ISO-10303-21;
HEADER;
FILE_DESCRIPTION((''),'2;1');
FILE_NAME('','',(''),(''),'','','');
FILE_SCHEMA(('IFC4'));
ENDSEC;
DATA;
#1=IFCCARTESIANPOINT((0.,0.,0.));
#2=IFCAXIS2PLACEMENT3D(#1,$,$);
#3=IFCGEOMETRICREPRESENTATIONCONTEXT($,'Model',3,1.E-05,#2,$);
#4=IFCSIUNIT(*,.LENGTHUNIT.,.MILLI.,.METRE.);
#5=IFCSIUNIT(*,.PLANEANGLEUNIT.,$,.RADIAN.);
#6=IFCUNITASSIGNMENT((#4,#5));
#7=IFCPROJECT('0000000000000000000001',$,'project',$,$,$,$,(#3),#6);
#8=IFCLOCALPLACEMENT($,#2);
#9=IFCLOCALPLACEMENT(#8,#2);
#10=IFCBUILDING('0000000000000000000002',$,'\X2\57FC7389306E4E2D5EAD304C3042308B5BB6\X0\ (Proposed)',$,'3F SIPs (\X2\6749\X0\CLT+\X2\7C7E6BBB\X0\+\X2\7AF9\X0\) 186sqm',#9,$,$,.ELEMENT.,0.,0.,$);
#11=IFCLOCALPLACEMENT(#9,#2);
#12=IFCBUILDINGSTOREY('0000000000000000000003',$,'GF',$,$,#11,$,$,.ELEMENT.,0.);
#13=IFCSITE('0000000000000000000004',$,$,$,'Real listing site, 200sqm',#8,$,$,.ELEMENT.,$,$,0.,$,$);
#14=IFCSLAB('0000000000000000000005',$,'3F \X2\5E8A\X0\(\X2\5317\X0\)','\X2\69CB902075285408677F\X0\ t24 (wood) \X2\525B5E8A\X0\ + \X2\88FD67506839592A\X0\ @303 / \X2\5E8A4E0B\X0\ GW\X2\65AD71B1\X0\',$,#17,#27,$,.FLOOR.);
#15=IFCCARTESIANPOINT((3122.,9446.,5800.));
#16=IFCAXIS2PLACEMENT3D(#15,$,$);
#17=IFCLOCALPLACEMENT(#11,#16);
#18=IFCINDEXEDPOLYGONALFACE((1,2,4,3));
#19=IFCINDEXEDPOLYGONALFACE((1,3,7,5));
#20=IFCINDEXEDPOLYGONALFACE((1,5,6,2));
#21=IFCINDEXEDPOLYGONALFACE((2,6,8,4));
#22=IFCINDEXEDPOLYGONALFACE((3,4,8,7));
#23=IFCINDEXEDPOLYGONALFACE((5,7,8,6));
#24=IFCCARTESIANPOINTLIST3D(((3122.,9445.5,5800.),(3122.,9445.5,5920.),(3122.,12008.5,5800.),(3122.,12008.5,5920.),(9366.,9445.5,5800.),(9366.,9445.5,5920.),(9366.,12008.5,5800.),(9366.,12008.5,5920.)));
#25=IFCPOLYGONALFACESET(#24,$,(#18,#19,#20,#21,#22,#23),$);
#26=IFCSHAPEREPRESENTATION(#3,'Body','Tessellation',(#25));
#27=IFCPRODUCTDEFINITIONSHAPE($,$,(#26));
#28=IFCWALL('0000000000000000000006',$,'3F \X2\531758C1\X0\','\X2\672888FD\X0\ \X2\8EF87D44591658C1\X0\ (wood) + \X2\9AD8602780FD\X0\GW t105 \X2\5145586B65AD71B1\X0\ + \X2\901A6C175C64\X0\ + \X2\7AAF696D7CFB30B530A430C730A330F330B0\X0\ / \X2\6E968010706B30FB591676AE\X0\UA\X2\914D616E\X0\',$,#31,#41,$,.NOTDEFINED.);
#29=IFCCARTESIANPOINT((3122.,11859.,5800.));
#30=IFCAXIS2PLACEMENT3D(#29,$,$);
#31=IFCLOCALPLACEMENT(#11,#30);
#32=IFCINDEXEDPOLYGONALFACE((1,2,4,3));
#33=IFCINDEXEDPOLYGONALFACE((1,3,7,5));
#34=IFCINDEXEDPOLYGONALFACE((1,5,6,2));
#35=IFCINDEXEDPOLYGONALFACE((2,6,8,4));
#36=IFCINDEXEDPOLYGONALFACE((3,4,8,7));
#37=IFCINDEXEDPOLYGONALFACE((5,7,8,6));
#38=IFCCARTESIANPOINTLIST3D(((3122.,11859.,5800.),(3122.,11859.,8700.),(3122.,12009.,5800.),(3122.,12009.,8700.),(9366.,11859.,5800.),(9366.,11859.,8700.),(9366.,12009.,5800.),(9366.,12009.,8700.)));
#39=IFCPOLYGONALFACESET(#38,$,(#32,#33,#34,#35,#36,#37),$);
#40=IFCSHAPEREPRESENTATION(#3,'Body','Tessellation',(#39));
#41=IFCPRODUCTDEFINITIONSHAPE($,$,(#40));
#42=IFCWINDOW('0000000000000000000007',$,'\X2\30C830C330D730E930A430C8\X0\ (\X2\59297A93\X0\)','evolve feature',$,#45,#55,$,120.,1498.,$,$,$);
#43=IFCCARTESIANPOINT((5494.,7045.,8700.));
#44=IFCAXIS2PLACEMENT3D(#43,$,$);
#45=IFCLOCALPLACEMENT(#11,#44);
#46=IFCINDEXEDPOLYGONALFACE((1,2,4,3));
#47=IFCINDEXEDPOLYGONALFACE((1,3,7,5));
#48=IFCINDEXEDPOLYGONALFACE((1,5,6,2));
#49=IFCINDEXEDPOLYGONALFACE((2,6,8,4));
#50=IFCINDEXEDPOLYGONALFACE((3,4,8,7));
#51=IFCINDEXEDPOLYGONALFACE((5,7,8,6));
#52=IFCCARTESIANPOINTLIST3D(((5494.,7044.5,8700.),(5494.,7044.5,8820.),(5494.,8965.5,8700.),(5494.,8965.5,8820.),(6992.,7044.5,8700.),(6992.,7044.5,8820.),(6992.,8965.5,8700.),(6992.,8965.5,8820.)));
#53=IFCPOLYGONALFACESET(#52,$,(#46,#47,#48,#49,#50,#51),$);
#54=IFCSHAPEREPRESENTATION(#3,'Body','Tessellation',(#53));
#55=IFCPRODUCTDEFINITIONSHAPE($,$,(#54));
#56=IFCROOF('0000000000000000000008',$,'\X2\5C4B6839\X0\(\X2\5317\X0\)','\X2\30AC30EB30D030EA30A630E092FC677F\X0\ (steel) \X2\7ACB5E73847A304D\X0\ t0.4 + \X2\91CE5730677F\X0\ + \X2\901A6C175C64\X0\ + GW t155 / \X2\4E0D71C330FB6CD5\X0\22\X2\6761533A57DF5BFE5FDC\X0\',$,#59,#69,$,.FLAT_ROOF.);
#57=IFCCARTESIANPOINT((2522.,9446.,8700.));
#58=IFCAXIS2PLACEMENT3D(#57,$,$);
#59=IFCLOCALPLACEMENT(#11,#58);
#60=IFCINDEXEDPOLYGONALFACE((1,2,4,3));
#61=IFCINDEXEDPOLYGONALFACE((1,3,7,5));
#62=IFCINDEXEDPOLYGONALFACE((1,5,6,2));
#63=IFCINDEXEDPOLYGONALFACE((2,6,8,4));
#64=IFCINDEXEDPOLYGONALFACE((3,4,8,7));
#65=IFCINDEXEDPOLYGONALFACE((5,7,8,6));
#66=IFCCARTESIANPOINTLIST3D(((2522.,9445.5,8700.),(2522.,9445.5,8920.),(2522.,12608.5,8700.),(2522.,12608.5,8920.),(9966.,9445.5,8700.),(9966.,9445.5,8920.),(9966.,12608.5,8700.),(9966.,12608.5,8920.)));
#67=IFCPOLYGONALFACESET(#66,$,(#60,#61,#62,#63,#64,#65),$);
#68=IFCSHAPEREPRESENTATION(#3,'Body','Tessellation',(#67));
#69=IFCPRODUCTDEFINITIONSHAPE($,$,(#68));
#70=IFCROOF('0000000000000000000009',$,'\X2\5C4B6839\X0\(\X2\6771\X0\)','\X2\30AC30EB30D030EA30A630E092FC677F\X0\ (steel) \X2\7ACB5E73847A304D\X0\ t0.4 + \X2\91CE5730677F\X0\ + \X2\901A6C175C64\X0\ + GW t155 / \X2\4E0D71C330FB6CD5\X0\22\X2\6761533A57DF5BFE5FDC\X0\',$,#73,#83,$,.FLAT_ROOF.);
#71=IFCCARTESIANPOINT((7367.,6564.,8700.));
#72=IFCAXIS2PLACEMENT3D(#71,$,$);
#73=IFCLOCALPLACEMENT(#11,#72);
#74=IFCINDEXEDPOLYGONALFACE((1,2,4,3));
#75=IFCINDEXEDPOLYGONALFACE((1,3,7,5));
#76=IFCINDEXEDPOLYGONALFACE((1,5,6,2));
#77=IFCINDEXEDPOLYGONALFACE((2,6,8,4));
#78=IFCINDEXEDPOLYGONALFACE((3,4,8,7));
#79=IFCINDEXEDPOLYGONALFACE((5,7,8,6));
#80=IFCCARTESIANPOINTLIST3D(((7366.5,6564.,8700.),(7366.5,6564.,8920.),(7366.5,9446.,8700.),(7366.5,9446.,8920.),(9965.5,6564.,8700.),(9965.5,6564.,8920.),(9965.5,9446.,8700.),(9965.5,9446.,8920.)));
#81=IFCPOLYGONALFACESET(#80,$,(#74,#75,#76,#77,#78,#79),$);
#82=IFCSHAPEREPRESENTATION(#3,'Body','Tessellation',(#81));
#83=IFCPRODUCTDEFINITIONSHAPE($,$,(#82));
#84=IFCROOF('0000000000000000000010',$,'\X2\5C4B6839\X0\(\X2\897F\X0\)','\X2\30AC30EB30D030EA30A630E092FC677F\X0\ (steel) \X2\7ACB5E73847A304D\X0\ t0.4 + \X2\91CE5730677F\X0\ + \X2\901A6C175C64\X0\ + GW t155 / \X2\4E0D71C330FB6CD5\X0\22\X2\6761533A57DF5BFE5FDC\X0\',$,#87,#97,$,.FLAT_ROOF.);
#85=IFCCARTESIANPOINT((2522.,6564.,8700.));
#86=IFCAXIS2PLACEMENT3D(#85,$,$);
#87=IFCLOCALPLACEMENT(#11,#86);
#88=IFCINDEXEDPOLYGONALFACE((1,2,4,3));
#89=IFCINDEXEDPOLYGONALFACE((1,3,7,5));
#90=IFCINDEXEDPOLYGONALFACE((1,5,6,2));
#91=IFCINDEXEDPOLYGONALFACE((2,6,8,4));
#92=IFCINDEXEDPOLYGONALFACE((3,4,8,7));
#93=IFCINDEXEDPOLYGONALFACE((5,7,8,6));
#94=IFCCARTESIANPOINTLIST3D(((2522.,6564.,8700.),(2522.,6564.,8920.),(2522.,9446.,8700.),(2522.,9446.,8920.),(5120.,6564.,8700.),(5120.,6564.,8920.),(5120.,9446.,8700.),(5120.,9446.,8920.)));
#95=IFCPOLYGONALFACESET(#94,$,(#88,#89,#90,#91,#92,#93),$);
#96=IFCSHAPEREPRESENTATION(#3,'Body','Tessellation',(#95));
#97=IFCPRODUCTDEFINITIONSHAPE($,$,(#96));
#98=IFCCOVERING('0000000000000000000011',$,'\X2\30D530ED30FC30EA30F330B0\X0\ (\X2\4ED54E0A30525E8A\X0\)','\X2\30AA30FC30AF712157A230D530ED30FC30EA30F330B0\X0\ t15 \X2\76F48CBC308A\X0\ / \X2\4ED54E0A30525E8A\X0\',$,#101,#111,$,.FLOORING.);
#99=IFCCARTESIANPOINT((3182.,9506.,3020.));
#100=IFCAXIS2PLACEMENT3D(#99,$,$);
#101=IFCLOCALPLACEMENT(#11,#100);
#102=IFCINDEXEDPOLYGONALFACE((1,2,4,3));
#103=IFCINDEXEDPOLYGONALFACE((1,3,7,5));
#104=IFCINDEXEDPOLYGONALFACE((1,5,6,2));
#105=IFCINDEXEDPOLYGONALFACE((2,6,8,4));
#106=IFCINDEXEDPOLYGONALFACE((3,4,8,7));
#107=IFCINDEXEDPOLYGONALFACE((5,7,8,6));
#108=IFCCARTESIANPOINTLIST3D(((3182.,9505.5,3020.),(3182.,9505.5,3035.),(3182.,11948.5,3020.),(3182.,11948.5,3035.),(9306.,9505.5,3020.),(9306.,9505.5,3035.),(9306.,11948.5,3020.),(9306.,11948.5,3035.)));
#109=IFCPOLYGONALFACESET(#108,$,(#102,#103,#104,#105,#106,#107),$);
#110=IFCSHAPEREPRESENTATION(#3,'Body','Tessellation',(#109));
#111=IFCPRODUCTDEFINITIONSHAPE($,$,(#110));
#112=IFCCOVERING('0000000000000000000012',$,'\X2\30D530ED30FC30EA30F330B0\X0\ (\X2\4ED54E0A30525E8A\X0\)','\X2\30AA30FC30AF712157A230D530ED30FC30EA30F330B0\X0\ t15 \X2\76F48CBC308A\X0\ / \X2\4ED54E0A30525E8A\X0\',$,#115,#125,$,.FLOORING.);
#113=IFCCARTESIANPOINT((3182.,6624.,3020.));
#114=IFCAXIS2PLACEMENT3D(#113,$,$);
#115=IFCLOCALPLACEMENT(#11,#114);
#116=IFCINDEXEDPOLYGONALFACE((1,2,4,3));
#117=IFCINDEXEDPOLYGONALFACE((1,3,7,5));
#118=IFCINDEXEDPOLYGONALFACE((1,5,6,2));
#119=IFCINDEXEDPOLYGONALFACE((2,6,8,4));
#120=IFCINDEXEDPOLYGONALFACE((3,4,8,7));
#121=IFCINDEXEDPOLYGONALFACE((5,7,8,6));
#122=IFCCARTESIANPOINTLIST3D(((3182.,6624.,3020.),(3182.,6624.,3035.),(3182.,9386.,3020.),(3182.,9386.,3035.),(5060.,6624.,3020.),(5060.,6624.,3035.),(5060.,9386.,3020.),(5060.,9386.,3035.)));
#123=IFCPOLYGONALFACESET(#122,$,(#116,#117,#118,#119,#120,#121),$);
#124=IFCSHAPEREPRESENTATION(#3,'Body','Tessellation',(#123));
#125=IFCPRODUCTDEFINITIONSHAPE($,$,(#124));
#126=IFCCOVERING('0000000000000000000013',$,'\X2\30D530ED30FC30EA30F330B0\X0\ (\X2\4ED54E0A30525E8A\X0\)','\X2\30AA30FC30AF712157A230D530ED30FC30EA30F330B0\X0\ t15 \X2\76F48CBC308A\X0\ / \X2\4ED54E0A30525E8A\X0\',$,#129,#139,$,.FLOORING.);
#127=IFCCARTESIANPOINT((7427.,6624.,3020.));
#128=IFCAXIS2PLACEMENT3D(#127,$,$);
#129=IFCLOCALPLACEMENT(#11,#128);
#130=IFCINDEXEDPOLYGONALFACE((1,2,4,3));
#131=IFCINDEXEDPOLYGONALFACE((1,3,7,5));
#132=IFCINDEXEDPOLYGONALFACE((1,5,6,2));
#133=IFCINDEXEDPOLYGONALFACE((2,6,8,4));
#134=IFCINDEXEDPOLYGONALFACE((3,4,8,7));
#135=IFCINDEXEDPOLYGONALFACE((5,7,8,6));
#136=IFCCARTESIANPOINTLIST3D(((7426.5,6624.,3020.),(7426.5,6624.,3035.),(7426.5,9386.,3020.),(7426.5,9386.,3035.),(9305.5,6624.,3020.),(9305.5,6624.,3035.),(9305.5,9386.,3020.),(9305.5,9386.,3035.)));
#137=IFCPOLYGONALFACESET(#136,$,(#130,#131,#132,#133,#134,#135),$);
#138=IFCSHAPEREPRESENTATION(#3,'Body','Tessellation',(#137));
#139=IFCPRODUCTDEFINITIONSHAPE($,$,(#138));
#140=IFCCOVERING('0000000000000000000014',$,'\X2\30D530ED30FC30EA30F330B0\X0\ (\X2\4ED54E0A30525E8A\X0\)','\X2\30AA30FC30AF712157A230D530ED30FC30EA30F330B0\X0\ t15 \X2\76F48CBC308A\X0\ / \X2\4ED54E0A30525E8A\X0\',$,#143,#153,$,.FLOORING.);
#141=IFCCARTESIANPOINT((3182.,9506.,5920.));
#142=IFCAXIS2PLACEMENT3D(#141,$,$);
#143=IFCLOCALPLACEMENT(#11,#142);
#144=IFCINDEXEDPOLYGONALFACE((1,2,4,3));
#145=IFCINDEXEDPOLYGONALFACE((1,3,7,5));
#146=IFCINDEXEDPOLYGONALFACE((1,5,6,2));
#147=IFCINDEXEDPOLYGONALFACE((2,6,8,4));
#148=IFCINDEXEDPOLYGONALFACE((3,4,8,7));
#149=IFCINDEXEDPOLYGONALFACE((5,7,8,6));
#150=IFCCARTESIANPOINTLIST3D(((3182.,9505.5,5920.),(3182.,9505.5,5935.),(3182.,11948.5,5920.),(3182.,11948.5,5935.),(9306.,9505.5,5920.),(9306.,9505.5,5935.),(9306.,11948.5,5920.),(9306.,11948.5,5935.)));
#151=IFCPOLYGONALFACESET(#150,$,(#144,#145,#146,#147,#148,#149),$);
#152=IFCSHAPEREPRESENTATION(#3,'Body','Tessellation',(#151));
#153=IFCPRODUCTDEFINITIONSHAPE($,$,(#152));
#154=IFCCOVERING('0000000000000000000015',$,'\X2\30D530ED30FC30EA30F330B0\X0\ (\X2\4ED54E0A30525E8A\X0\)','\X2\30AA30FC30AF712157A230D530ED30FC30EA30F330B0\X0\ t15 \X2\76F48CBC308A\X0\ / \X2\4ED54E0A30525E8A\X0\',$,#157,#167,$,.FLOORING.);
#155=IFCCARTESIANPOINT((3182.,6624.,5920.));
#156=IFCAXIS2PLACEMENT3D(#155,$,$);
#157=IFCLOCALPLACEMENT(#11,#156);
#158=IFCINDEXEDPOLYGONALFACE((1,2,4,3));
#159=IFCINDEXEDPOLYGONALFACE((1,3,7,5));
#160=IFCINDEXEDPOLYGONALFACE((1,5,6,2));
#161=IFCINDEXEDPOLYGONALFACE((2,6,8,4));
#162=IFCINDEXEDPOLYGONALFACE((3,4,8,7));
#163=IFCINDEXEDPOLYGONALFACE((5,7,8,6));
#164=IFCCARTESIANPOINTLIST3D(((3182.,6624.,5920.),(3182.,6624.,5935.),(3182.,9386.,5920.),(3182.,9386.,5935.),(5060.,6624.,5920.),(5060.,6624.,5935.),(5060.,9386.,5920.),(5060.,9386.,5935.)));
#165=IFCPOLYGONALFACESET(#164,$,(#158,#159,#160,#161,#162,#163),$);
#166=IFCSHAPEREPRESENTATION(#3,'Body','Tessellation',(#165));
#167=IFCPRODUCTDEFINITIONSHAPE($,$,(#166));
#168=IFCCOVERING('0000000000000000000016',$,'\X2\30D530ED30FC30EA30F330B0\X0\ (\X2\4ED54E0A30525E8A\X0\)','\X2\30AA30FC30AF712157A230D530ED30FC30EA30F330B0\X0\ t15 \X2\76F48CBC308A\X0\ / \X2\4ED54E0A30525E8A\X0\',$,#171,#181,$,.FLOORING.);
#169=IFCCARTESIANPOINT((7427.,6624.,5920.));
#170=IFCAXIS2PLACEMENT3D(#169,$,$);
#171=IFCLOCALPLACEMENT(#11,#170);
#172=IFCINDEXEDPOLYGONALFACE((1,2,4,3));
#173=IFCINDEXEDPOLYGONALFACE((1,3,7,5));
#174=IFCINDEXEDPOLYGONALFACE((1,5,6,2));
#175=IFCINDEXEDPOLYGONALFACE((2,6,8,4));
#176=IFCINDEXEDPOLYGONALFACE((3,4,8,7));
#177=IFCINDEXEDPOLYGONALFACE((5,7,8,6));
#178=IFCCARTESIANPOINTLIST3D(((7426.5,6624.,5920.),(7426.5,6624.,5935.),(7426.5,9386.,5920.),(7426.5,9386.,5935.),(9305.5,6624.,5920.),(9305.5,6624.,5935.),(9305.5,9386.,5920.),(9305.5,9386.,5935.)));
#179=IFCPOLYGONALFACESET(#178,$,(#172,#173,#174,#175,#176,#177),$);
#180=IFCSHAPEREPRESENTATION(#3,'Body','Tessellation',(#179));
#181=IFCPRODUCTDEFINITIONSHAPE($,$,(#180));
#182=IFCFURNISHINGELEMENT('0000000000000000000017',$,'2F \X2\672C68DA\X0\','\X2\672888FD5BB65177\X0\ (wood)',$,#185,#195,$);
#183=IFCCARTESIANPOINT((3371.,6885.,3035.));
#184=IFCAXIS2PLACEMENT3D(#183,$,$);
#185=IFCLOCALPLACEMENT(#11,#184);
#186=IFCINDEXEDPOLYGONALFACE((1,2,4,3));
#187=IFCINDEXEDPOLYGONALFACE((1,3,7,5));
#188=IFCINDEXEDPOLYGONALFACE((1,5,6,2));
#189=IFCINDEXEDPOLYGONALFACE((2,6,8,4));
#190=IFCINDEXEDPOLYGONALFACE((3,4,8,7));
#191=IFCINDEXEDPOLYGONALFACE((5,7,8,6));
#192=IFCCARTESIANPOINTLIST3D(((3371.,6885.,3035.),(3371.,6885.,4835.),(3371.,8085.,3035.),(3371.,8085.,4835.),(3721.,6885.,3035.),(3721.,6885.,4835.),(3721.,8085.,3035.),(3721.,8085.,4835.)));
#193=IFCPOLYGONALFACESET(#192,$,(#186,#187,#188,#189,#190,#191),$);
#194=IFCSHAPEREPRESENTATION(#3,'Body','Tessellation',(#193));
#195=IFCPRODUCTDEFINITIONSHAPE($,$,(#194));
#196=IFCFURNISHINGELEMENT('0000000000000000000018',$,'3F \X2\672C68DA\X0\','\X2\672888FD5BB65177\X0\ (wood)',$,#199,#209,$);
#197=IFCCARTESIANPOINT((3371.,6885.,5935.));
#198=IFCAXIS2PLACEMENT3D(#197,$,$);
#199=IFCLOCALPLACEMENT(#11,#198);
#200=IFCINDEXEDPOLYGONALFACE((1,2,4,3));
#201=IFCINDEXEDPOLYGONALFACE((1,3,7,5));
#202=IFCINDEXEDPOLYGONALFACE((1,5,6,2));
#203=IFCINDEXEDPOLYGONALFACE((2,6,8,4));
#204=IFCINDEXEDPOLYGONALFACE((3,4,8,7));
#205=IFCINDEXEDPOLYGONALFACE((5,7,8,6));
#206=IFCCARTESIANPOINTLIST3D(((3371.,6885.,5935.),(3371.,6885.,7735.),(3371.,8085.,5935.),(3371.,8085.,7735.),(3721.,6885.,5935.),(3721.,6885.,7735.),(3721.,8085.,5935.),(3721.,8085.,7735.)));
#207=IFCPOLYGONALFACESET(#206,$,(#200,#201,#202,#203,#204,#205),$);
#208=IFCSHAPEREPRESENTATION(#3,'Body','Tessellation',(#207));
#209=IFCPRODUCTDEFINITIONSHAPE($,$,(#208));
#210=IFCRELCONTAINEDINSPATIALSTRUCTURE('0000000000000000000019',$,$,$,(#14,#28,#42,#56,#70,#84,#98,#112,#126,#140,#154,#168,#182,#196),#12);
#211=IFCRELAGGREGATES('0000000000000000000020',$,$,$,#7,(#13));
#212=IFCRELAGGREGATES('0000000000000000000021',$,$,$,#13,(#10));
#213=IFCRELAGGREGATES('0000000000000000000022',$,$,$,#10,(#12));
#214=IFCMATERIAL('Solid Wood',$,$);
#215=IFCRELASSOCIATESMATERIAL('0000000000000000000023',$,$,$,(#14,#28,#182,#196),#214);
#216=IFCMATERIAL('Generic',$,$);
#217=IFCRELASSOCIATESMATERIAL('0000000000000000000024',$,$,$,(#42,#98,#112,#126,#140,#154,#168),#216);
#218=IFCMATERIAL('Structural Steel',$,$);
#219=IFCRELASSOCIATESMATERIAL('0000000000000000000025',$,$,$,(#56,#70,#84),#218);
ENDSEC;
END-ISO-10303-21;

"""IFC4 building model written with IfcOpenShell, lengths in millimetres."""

from ifc_helpers import new_model, si_unit, frame, frame_2d, origin, place, context, project, spatial, rectangle, extrude, material, element, save


model = new_model("IFC4")

# Units and contexts
model_context = context("Model", 3, precision=1e-05, world=origin())
ifc_project = project(units=[si_unit("LENGTHUNIT", "METRE", prefix="MILLI"), si_unit("PLANEANGLEUNIT", "RADIAN")], contexts=[model_context])

# Site, building, storey
site_placement = place(None, origin())
site = spatial("IfcSite", under=ifc_project, at=site_placement, ObjectType="Real listing site, 200sqm", CompositionType="ELEMENT", RefElevation=0.0)
building_placement = place(site_placement, origin())
building = spatial("IfcBuilding", under=site, at=building_placement, Name="埼玉の中庭がある家 (Proposed)", ObjectType="3F SIPs (杉CLT+籾殻+竹) 186sqm", CompositionType="ELEMENT", ElevationOfRefHeight=0.0, ElevationOfTerrain=0.0)
storey_placement = place(building_placement, origin())
storey = spatial("IfcBuildingStorey", under=building, at=storey_placement, Name="GF", CompositionType="ELEMENT", Elevation=0.0)

# Slab
ifc_material_1 = material(Name="Solid Wood")
slab_placement = place(storey_placement, frame((3122.0, 9446.0, 5800.0)))
element("IfcSlab", 1, at=slab_placement, inside=storey, material=ifc_material_1, Name="3F 床(北)", Description="構造用合板 t24 (wood) 剛床 + 製材根太 @303 / 床下 GW断熱", PredefinedType="FLOOR", context=model_context, shape_type="SweptSolid", body=[
    extrude(rectangle(XDim=6244.0, YDim=2563.0, at=frame_2d((3122.0, 1281.0))), frame((3122.0, 9446.0, 5800.0)), (0.0, 0.0, 1.0), 120.0),
])

# Wall
wall_1_placement = place(storey_placement, frame((3122.0, 11859.0, 5800.0)))
element("IfcWall", 2, at=wall_1_placement, inside=storey, material=ifc_material_1, Name="3F 北壁", Description="木製 軸組外壁 (wood) + 高性能GW t105 充填断熱 + 通気層 + 窯業系サイディング / 準耐火・外皮UA配慮", PredefinedType="NOTDEFINED", context=model_context, shape_type="SweptSolid", body=[
    extrude(rectangle(XDim=6244.0, YDim=150.0, at=frame_2d((3122.0, 75.0))), frame((3122.0, 11859.0, 5800.0)), (0.0, 0.0, 1.0), 2900.0),
])

# Window
ifc_material_2 = material(Name="Generic")
window_1_placement = place(storey_placement, frame((5494.0, 7045.0, 8700.0)))
element("IfcWindow", 3, at=window_1_placement, inside=storey, material=ifc_material_2, Name="トップライト (天窓)", Description="evolve feature", OverallHeight=120.0, OverallWidth=1498.0, context=model_context, shape_type="SweptSolid", body=[
    extrude(rectangle(XDim=1498.0, YDim=1921.0, at=frame_2d((749.0, 960.0))), frame((5494.0, 7045.0, 8700.0)), (0.0, 0.0, 1.0), 120.0),
])

# Roofs
ifc_material_3 = material(Name="Structural Steel")
roof_1_placement = place(storey_placement, frame((2522.0, 9446.0, 8700.0)))
element("IfcRoof", 4, at=roof_1_placement, inside=storey, material=ifc_material_3, Name="屋根(北)", Description="ガルバリウム鋼板 (steel) 立平葺き t0.4 + 野地板 + 通気層 + GW t155 / 不燃・法22条区域対応", PredefinedType="FLAT_ROOF", context=model_context, shape_type="SweptSolid", body=[
    extrude(rectangle(XDim=7444.0, YDim=3163.0, at=frame_2d((3722.0, 1581.0))), frame((2522.0, 9446.0, 8700.0)), (0.0, 0.0, 1.0), 220.0),
])
roof_2_placement = place(storey_placement, frame((7367.0, 6564.0, 8700.0)))
element("IfcRoof", 5, at=roof_2_placement, inside=storey, material=ifc_material_3, Name="屋根(東)", Description="ガルバリウム鋼板 (steel) 立平葺き t0.4 + 野地板 + 通気層 + GW t155 / 不燃・法22条区域対応", PredefinedType="FLAT_ROOF", context=model_context, shape_type="SweptSolid", body=[
    extrude(rectangle(XDim=2599.0, YDim=2882.0, at=frame_2d((1299.0, 1441.0))), frame((7367.0, 6564.0, 8700.0)), (0.0, 0.0, 1.0), 220.0),
])
roof_3_placement = place(storey_placement, frame((2522.0, 6564.0, 8700.0)))
element("IfcRoof", 6, at=roof_3_placement, inside=storey, material=ifc_material_3, Name="屋根(西)", Description="ガルバリウム鋼板 (steel) 立平葺き t0.4 + 野地板 + 通気層 + GW t155 / 不燃・法22条区域対応", PredefinedType="FLAT_ROOF", context=model_context, shape_type="SweptSolid", body=[
    extrude(rectangle(XDim=2598.0, YDim=2882.0, at=frame_2d((1299.0, 1441.0))), frame((2522.0, 6564.0, 8700.0)), (0.0, 0.0, 1.0), 220.0),
])

# Coverings
covering_1_placement = place(storey_placement, frame((3182.0, 9506.0, 3020.0)))
element("IfcCovering", 7, at=covering_1_placement, inside=storey, material=ifc_material_2, Name="フローリング (仕上げ床)", Description="オーク無垢フローリング t15 直貼り / 仕上げ床", PredefinedType="FLOORING", context=model_context, shape_type="SweptSolid", body=[
    extrude(rectangle(XDim=6124.0, YDim=2443.0, at=frame_2d((3062.0, 1221.0))), frame((3182.0, 9506.0, 3020.0)), (0.0, 0.0, 1.0), 15.0),
])
covering_2_placement = place(storey_placement, frame((3182.0, 6624.0, 3020.0)))
element("IfcCovering", 8, at=covering_2_placement, inside=storey, material=ifc_material_2, Name="フローリング (仕上げ床)", Description="オーク無垢フローリング t15 直貼り / 仕上げ床", PredefinedType="FLOORING", context=model_context, shape_type="SweptSolid", body=[
    extrude(rectangle(XDim=1878.0, YDim=2762.0, at=frame_2d((939.0, 1381.0))), frame((3182.0, 6624.0, 3020.0)), (0.0, 0.0, 1.0), 15.0),
])
covering_3_placement = place(storey_placement, frame((7427.0, 6624.0, 3020.0)))
element("IfcCovering", 9, at=covering_3_placement, inside=storey, material=ifc_material_2, Name="フローリング (仕上げ床)", Description="オーク無垢フローリング t15 直貼り / 仕上げ床", PredefinedType="FLOORING", context=model_context, shape_type="SweptSolid", body=[
    extrude(rectangle(XDim=1879.0, YDim=2762.0, at=frame_2d((939.0, 1381.0))), frame((7427.0, 6624.0, 3020.0)), (0.0, 0.0, 1.0), 15.0),
])
covering_4_placement = place(storey_placement, frame((3182.0, 9506.0, 5920.0)))
element("IfcCovering", 10, at=covering_4_placement, inside=storey, material=ifc_material_2, Name="フローリング (仕上げ床)", Description="オーク無垢フローリング t15 直貼り / 仕上げ床", PredefinedType="FLOORING", context=model_context, shape_type="SweptSolid", body=[
    extrude(rectangle(XDim=6124.0, YDim=2443.0, at=frame_2d((3062.0, 1221.0))), frame((3182.0, 9506.0, 5920.0)), (0.0, 0.0, 1.0), 15.0),
])
covering_5_placement = place(storey_placement, frame((3182.0, 6624.0, 5920.0)))
element("IfcCovering", 11, at=covering_5_placement, inside=storey, material=ifc_material_2, Name="フローリング (仕上げ床)", Description="オーク無垢フローリング t15 直貼り / 仕上げ床", PredefinedType="FLOORING", context=model_context, shape_type="SweptSolid", body=[
    extrude(rectangle(XDim=1878.0, YDim=2762.0, at=frame_2d((939.0, 1381.0))), frame((3182.0, 6624.0, 5920.0)), (0.0, 0.0, 1.0), 15.0),
])
covering_6_placement = place(storey_placement, frame((7427.0, 6624.0, 5920.0)))
element("IfcCovering", 12, at=covering_6_placement, inside=storey, material=ifc_material_2, Name="フローリング (仕上げ床)", Description="オーク無垢フローリング t15 直貼り / 仕上げ床", PredefinedType="FLOORING", context=model_context, shape_type="SweptSolid", body=[
    extrude(rectangle(XDim=1879.0, YDim=2762.0, at=frame_2d((939.0, 1381.0))), frame((7427.0, 6624.0, 5920.0)), (0.0, 0.0, 1.0), 15.0),
])

# Furnishing elements
furnishing_1_placement = place(storey_placement, frame((3371.0, 6885.0, 3035.0)))
element("IfcFurnishingElement", 13, at=furnishing_1_placement, inside=storey, material=ifc_material_1, Name="2F 本棚", Description="木製家具 (wood)", context=model_context, shape_type="SweptSolid", body=[
    extrude(rectangle(XDim=350.0, YDim=1200.0, at=frame_2d((175.0, 600.0))), frame((3371.0, 6885.0, 3035.0)), (0.0, 0.0, 1.0), 1800.0),
])
furnishing_2_placement = place(storey_placement, frame((3371.0, 6885.0, 5935.0)))
element("IfcFurnishingElement", 14, at=furnishing_2_placement, inside=storey, material=ifc_material_1, Name="3F 本棚", Description="木製家具 (wood)", context=model_context, shape_type="SweptSolid", body=[
    extrude(rectangle(XDim=350.0, YDim=1200.0, at=frame_2d((175.0, 600.0))), frame((3371.0, 6885.0, 5935.0)), (0.0, 0.0, 1.0), 1800.0),
])

save(model, "model.ifc")
